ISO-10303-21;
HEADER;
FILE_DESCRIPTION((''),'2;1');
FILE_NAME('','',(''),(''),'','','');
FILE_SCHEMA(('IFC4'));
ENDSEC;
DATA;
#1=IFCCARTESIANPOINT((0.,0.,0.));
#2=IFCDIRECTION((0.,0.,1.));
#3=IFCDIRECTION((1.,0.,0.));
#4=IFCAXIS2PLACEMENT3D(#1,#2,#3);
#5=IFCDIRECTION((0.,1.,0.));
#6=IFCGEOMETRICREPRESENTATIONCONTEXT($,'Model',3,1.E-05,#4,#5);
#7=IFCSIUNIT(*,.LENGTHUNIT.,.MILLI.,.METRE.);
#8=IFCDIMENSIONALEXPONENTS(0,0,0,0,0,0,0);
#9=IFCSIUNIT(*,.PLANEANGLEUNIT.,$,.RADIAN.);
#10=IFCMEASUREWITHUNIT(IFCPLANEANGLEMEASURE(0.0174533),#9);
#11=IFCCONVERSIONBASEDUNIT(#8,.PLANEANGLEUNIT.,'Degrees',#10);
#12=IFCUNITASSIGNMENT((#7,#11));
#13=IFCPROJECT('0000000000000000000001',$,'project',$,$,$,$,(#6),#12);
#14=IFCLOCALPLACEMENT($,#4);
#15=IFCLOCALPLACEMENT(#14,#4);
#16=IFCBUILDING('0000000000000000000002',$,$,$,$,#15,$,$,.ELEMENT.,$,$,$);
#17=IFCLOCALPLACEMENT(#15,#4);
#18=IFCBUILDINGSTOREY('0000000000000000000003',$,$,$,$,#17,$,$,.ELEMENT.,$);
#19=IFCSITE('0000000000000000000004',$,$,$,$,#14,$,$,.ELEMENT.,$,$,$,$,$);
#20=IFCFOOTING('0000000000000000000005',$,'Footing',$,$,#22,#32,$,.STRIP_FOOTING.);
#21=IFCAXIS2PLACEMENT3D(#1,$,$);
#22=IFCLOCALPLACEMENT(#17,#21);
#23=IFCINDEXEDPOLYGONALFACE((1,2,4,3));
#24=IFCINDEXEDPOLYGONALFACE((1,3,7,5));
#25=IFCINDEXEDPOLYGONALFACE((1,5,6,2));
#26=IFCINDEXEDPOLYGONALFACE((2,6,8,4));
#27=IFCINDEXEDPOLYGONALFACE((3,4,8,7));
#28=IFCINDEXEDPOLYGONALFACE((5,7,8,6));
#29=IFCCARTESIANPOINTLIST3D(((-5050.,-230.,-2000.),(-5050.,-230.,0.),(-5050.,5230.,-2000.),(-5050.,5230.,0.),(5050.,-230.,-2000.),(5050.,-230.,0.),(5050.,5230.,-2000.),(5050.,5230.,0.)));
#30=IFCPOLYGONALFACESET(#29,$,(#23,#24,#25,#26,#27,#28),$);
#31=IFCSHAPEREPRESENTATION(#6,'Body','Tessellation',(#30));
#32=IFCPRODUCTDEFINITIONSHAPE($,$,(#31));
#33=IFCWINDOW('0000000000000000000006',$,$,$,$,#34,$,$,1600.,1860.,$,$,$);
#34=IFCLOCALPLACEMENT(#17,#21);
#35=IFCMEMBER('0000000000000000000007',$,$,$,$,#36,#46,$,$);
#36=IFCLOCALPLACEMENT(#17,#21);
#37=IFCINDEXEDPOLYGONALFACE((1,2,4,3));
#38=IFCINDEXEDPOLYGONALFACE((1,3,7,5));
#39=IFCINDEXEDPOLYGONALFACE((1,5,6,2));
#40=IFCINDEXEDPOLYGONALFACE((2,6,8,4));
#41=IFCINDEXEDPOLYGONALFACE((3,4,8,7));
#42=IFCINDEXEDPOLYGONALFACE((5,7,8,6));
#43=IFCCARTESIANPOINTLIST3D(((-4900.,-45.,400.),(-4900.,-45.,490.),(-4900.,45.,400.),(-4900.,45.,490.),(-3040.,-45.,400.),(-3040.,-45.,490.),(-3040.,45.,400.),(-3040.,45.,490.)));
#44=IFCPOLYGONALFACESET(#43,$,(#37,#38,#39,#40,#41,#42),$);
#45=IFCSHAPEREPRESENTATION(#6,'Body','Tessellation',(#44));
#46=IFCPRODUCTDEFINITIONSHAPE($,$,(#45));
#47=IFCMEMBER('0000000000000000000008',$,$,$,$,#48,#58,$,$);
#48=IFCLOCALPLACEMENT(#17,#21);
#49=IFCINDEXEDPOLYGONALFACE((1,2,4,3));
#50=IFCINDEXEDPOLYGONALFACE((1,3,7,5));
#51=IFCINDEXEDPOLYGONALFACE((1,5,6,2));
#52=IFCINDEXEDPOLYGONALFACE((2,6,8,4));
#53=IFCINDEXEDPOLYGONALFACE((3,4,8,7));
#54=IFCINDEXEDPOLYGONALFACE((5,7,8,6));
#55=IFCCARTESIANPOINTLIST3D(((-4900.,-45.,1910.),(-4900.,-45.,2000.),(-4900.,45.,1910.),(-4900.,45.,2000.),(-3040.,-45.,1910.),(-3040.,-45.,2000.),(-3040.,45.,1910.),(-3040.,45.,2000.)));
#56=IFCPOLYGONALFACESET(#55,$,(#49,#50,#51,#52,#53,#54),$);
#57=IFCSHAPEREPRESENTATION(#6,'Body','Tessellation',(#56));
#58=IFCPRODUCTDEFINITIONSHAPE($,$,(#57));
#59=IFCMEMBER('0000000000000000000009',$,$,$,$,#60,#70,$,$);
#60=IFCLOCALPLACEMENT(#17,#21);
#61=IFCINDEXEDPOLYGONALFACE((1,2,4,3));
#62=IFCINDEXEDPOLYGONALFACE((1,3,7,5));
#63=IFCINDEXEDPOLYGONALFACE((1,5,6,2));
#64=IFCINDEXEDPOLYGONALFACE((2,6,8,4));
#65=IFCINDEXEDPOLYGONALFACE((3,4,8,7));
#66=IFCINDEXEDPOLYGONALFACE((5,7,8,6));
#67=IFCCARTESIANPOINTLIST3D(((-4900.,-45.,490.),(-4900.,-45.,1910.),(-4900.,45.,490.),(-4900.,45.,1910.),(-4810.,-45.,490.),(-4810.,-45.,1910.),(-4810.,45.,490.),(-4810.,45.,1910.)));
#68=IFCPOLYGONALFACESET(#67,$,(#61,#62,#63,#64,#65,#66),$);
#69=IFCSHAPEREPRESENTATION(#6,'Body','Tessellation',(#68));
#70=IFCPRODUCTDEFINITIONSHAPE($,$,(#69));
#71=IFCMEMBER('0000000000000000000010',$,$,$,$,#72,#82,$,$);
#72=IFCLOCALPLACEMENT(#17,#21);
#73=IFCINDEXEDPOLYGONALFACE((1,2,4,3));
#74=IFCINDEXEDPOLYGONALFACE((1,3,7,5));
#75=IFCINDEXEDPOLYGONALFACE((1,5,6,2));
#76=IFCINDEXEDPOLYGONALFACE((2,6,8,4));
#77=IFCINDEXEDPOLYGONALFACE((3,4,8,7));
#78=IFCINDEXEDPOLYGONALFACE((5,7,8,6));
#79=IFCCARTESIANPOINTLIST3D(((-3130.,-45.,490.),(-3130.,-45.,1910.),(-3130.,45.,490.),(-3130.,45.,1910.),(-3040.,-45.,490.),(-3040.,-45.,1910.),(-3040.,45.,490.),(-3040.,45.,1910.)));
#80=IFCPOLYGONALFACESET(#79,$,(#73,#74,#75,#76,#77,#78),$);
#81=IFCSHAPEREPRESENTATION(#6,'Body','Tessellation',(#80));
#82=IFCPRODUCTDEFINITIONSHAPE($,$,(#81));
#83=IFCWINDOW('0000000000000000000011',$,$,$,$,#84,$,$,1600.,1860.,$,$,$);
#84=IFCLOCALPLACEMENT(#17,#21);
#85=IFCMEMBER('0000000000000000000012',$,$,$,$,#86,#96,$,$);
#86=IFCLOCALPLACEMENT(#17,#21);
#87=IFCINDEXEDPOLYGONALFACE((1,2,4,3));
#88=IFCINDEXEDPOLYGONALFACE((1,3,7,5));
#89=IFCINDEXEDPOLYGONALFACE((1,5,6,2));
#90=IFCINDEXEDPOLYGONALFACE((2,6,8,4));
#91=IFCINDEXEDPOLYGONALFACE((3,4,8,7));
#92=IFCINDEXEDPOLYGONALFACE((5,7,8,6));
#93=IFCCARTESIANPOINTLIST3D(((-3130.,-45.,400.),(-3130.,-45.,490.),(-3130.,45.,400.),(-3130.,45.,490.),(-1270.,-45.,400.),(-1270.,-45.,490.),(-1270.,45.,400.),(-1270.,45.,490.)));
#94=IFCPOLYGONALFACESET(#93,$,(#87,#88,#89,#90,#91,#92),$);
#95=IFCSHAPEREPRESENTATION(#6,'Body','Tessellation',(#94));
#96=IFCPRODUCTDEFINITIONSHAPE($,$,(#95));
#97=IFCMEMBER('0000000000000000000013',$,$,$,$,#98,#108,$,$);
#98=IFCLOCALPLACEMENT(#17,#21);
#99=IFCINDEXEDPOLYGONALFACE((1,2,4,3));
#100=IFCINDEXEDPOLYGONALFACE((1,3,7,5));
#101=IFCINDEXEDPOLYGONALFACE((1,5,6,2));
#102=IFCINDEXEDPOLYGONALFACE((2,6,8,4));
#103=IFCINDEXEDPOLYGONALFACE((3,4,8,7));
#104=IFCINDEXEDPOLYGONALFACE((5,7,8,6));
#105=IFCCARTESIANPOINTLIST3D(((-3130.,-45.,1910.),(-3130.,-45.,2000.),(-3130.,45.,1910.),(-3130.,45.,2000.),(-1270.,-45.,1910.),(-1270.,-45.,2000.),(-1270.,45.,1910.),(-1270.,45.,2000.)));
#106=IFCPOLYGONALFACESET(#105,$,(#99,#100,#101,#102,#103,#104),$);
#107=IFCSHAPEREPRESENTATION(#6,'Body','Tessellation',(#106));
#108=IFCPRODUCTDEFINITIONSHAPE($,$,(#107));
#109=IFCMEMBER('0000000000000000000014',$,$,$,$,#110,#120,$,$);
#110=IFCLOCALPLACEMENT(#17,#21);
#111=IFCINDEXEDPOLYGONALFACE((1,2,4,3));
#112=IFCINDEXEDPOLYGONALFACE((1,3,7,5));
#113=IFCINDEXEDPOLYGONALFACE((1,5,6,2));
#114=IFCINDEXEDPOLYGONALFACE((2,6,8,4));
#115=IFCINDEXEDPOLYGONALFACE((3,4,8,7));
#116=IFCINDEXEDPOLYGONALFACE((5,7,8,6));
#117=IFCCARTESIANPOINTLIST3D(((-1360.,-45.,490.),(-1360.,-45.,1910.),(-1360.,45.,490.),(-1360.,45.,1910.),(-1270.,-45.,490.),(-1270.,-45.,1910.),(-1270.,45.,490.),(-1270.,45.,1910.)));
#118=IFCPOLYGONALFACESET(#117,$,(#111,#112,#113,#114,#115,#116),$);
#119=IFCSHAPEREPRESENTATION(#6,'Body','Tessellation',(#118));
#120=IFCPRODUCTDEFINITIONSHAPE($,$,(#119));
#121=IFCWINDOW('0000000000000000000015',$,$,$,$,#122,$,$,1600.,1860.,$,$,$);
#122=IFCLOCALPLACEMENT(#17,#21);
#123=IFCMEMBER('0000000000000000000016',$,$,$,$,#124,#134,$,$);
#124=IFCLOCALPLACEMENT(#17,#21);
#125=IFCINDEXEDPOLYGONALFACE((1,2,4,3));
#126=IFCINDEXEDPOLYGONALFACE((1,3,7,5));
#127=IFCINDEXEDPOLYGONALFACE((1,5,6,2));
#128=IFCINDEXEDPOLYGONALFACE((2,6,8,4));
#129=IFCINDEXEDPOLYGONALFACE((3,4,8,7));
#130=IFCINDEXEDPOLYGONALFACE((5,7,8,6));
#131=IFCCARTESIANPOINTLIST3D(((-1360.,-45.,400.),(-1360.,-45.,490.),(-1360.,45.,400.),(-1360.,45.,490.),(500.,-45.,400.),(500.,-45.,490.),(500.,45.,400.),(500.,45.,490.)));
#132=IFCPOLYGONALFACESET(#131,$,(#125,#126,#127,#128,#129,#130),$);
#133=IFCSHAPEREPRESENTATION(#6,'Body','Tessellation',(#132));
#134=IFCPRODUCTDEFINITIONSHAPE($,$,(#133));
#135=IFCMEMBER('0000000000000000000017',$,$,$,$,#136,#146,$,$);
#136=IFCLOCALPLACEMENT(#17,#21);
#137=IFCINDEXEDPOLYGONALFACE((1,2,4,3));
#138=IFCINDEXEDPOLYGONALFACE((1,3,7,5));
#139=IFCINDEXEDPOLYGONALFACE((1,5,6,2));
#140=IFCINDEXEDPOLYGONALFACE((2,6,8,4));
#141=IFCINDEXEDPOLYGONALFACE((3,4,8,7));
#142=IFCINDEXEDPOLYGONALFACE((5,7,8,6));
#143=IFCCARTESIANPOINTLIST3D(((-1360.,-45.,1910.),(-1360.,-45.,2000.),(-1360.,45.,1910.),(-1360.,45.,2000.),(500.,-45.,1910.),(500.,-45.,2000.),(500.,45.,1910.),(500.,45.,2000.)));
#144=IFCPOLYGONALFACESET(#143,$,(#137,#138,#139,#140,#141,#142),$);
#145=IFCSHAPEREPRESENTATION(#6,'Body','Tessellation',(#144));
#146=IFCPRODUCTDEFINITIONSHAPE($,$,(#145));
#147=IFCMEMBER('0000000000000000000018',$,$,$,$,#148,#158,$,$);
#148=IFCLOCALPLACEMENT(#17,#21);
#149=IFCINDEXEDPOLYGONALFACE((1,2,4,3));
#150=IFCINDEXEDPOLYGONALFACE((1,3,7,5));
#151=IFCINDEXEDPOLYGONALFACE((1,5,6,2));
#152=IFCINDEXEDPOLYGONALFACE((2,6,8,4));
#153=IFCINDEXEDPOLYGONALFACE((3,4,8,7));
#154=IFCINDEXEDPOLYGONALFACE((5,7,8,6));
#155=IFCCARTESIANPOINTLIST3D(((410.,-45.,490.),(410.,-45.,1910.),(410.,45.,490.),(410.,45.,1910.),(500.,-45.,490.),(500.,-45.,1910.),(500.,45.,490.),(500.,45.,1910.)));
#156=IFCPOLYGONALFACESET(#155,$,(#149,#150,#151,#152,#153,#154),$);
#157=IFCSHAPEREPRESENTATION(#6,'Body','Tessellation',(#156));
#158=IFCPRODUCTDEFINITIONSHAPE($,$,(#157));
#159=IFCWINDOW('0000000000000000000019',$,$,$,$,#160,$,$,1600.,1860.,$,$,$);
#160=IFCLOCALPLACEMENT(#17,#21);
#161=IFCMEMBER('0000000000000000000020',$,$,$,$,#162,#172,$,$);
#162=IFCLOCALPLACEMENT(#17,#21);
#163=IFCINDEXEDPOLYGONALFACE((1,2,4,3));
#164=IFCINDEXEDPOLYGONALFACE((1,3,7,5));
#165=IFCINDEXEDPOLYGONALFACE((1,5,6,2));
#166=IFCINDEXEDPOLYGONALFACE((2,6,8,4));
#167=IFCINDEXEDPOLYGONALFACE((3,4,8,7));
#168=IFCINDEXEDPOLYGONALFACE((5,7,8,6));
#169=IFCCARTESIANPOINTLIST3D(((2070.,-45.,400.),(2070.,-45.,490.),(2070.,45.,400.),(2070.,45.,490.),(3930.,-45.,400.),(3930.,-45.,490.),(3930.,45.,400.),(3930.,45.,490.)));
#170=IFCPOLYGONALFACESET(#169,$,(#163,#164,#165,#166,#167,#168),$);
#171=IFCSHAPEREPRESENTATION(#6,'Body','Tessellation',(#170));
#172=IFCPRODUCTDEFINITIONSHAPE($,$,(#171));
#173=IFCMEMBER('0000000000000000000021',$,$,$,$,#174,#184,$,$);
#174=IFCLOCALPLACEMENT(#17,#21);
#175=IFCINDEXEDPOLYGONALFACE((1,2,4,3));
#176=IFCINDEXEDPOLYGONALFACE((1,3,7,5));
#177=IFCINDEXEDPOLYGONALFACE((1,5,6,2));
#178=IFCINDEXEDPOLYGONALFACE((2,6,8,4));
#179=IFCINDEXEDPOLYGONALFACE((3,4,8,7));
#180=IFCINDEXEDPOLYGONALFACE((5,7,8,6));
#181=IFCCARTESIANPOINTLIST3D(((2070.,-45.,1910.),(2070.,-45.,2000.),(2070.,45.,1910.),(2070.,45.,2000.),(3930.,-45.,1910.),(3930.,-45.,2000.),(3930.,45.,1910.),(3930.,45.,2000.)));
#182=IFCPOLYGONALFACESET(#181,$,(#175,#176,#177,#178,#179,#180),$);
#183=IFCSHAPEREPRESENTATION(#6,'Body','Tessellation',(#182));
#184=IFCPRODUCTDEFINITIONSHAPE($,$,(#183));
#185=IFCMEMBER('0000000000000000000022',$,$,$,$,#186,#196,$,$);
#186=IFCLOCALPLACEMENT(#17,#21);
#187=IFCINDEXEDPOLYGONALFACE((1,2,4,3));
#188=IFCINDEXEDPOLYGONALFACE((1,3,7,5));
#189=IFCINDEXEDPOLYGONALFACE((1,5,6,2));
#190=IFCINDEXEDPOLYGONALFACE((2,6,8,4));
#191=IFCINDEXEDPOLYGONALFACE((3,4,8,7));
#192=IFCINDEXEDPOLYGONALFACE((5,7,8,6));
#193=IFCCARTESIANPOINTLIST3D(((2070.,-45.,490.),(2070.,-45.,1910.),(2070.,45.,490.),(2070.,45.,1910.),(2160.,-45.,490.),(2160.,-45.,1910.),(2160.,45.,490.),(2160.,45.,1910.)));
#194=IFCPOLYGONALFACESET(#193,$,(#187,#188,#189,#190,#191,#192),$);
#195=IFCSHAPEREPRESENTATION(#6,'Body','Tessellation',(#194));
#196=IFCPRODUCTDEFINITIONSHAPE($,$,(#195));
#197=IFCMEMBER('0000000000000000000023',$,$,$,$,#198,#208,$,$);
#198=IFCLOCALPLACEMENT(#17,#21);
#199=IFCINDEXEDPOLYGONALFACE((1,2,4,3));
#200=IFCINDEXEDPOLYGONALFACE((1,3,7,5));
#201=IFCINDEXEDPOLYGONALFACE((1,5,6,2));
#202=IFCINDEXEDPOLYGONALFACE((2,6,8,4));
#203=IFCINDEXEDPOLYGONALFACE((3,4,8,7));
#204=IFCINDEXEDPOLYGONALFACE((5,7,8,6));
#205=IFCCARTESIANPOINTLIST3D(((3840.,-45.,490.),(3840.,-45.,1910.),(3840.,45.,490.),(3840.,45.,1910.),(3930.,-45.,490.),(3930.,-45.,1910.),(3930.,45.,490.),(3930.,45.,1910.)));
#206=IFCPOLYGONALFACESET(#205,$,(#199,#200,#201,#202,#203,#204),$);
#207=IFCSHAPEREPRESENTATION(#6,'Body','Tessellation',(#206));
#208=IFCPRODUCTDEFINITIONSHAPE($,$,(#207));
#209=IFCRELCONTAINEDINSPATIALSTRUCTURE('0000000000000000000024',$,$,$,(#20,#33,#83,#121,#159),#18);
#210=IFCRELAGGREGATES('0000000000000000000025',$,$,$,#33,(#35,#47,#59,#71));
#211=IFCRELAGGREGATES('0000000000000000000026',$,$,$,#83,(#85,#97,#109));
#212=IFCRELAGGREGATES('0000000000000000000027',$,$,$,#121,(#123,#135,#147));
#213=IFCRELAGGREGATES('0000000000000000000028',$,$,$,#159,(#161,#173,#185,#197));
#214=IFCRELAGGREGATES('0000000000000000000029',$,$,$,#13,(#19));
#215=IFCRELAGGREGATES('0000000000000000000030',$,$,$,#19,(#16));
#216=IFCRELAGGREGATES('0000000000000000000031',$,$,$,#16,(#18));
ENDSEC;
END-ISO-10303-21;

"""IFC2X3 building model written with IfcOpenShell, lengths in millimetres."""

from ifc_helpers import new_model, entity, si_unit, converted_unit, direction, frame, origin_with_axes, place, context, project, spatial, polyline, outline, extrude, element, aggregate, save


model = new_model("IFC2X3")

# Units and contexts
model_context = context("Model", 3, precision=1e-05, world=origin_with_axes(), true_north=direction((0.0, 1.0, 0.0)))
ifc_project = project(units=[si_unit("LENGTHUNIT", "METRE", prefix="MILLI"), converted_unit("PLANEANGLEUNIT", "Degrees", entity("IfcPlaneAngleMeasure", 0.0174533), si_unit("PLANEANGLEUNIT", "RADIAN"), dimensions=[0, 0, 0, 0, 0, 0, 0])], contexts=[model_context])

# Site, building, storey
placement = place(None, origin_with_axes())
site = spatial("IfcSite", under=ifc_project, at=placement, CompositionType="ELEMENT")
building_placement = place(placement, origin_with_axes())
building = spatial("IfcBuilding", under=site, at=building_placement, CompositionType="ELEMENT")
storey_placement = place(building_placement, origin_with_axes())
storey = spatial("IfcBuildingStorey", under=building, at=storey_placement, CompositionType="ELEMENT")

# Footing
footing_placement = place(None, frame((0.0, 2500.0, -2000.0), z_axis=(0.0, 0.0, 1.0), x_axis=(1.0, 0.0, 0.0)))
element("IfcFooting", 1, at=footing_placement, inside=storey, Name="Footing", PredefinedType="STRIP_FOOTING", context=model_context, shape_type="SweptSolid", body=[
    extrude(outline(polyline([(-5050.0, -2730.0), (5050.0, -2730.0), (5050.0, 2730.0), (-5050.0, 2730.0), (-5050.0, -2730.0), (-5050.0, -2730.0)])), origin_with_axes(), (0.0, 0.0, 1.0), 2000.0),
])

# Windows, members
window_1_placement = place(storey_placement, frame((-4900.0, -45.0, 400.0), z_axis=(0.0, 0.0, 1.0), x_axis=(1.0, 0.0, 0.0)))
window_1 = element("IfcWindow", 2, at=window_1_placement, inside=storey, OverallHeight=1600.0, OverallWidth=1860.0)
member_1_placement = place(window_1_placement, frame((930.0, 45.0, 0.0), z_axis=(0.0, 0.0, 1.0), x_axis=(1.0, 0.0, 0.0)))
member_1 = element("IfcMember", 3, at=member_1_placement, context=model_context, shape_type="SweptSolid", body=[
    extrude(outline(polyline([(-930.0, -45.0), (930.0, -45.0), (930.0, 45.0), (-930.0, 45.0), (-930.0, -45.0), (-930.0, -45.0)])), origin_with_axes(), (0.0, 0.0, 1.0), 90.0),
])
member_2_placement = place(window_1_placement, frame((930.0, 45.0, 1510.0), z_axis=(0.0, 0.0, 1.0), x_axis=(1.0, 0.0, 0.0)))
member_2 = element("IfcMember", 4, at=member_2_placement, context=model_context, shape_type="SweptSolid", body=[
    extrude(outline(polyline([(-930.0, -45.0), (930.0, -45.0), (930.0, 45.0), (-930.0, 45.0), (-930.0, -45.0), (-930.0, -45.0)])), origin_with_axes(), (0.0, 0.0, 1.0), 90.0),
])
member_3_placement = place(window_1_placement, frame((45.0, 45.0, 90.0), z_axis=(0.0, 0.0, 1.0), x_axis=(1.0, 0.0, 0.0)))
member_3 = element("IfcMember", 5, at=member_3_placement, context=model_context, shape_type="SweptSolid", body=[
    extrude(outline(polyline([(-45.0, -45.0), (45.0, -45.0), (45.0, 45.0), (-45.0, 45.0), (-45.0, -45.0), (-45.0, -45.0)])), origin_with_axes(), (0.0, 0.0, 1.0), 1420.0),
])
member_4_placement = place(window_1_placement, frame((1815.0, 45.0, 90.0), z_axis=(0.0, 0.0, 1.0), x_axis=(1.0, 0.0, 0.0)))
member_4 = element("IfcMember", 6, at=member_4_placement, context=model_context, shape_type="SweptSolid", body=[
    extrude(outline(polyline([(-45.0, -45.0), (45.0, -45.0), (45.0, 45.0), (-45.0, 45.0), (-45.0, -45.0), (-45.0, -45.0)])), origin_with_axes(), (0.0, 0.0, 1.0), 1420.0),
])
window_2_placement = place(storey_placement, frame((-3130.0, -45.0, 400.0), z_axis=(0.0, 0.0, 1.0), x_axis=(1.0, 0.0, 0.0)))
window_2 = element("IfcWindow", 7, at=window_2_placement, inside=storey, OverallHeight=1600.0, OverallWidth=1860.0)
member_5_placement = place(window_2_placement, frame((930.0, 45.0, 0.0), z_axis=(0.0, 0.0, 1.0), x_axis=(1.0, 0.0, 0.0)))
member_5 = element("IfcMember", 8, at=member_5_placement, context=model_context, shape_type="SweptSolid", body=[
    extrude(outline(polyline([(-930.0, -45.0), (930.0, -45.0), (930.0, 45.0), (-930.0, 45.0), (-930.0, -45.0), (-930.0, -45.0)])), origin_with_axes(), (0.0, 0.0, 1.0), 90.0),
])
member_6_placement = place(window_2_placement, frame((930.0, 45.0, 1510.0), z_axis=(0.0, 0.0, 1.0), x_axis=(1.0, 0.0, 0.0)))
member_6 = element("IfcMember", 9, at=member_6_placement, context=model_context, shape_type="SweptSolid", body=[
    extrude(outline(polyline([(-930.0, -45.0), (930.0, -45.0), (930.0, 45.0), (-930.0, 45.0), (-930.0, -45.0), (-930.0, -45.0)])), origin_with_axes(), (0.0, 0.0, 1.0), 90.0),
])
member_7_placement = place(window_2_placement, frame((1815.0, 45.0, 90.0), z_axis=(0.0, 0.0, 1.0), x_axis=(1.0, 0.0, 0.0)))
member_7 = element("IfcMember", 10, at=member_7_placement, context=model_context, shape_type="SweptSolid", body=[
    extrude(outline(polyline([(-45.0, -45.0), (45.0, -45.0), (45.0, 45.0), (-45.0, 45.0), (-45.0, -45.0), (-45.0, -45.0)])), origin_with_axes(), (0.0, 0.0, 1.0), 1420.0),
])
window_3_placement = place(storey_placement, frame((-1360.0, -45.0, 400.0), z_axis=(0.0, 0.0, 1.0), x_axis=(1.0, 0.0, 0.0)))
window_3 = element("IfcWindow", 11, at=window_3_placement, inside=storey, OverallHeight=1600.0, OverallWidth=1860.0)
member_8_placement = place(window_3_placement, frame((930.0, 45.0, 0.0), z_axis=(0.0, 0.0, 1.0), x_axis=(1.0, 0.0, 0.0)))
member_8 = element("IfcMember", 12, at=member_8_placement, context=model_context, shape_type="SweptSolid", body=[
    extrude(outline(polyline([(-930.0, -45.0), (930.0, -45.0), (930.0, 45.0), (-930.0, 45.0), (-930.0, -45.0), (-930.0, -45.0)])), origin_with_axes(), (0.0, 0.0, 1.0), 90.0),
])
member_9_placement = place(window_3_placement, frame((930.0, 45.0, 1510.0), z_axis=(0.0, 0.0, 1.0), x_axis=(1.0, 0.0, 0.0)))
member_9 = element("IfcMember", 13, at=member_9_placement, context=model_context, shape_type="SweptSolid", body=[
    extrude(outline(polyline([(-930.0, -45.0), (930.0, -45.0), (930.0, 45.0), (-930.0, 45.0), (-930.0, -45.0), (-930.0, -45.0)])), origin_with_axes(), (0.0, 0.0, 1.0), 90.0),
])
member_10_placement = place(window_3_placement, frame((1815.0, 45.0, 90.0), z_axis=(0.0, 0.0, 1.0), x_axis=(1.0, 0.0, 0.0)))
member_10 = element("IfcMember", 14, at=member_10_placement, context=model_context, shape_type="SweptSolid", body=[
    extrude(outline(polyline([(-45.0, -45.0), (45.0, -45.0), (45.0, 45.0), (-45.0, 45.0), (-45.0, -45.0), (-45.0, -45.0)])), origin_with_axes(), (0.0, 0.0, 1.0), 1420.0),
])
window_4_placement = place(storey_placement, frame((2070.0, -45.0, 400.0), z_axis=(0.0, 0.0, 1.0), x_axis=(1.0, 0.0, 0.0)))
window_4 = element("IfcWindow", 15, at=window_4_placement, inside=storey, OverallHeight=1600.0, OverallWidth=1860.0)
member_11_placement = place(window_4_placement, frame((930.0, 45.0, 0.0), z_axis=(0.0, 0.0, 1.0), x_axis=(1.0, 0.0, 0.0)))
member_11 = element("IfcMember", 16, at=member_11_placement, context=model_context, shape_type="SweptSolid", body=[
    extrude(outline(polyline([(-930.0, -45.0), (930.0, -45.0), (930.0, 45.0), (-930.0, 45.0), (-930.0, -45.0), (-930.0, -45.0)])), origin_with_axes(), (0.0, 0.0, 1.0), 90.0),
])
member_12_placement = place(window_4_placement, frame((930.0, 45.0, 1510.0), z_axis=(0.0, 0.0, 1.0), x_axis=(1.0, 0.0, 0.0)))
member_12 = element("IfcMember", 17, at=member_12_placement, context=model_context, shape_type="SweptSolid", body=[
    extrude(outline(polyline([(-930.0, -45.0), (930.0, -45.0), (930.0, 45.0), (-930.0, 45.0), (-930.0, -45.0), (-930.0, -45.0)])), origin_with_axes(), (0.0, 0.0, 1.0), 90.0),
])
member_13_placement = place(window_4_placement, frame((45.0, 45.0, 90.0), z_axis=(0.0, 0.0, 1.0), x_axis=(1.0, 0.0, 0.0)))
member_13 = element("IfcMember", 18, at=member_13_placement, context=model_context, shape_type="SweptSolid", body=[
    extrude(outline(polyline([(-45.0, -45.0), (45.0, -45.0), (45.0, 45.0), (-45.0, 45.0), (-45.0, -45.0), (-45.0, -45.0)])), origin_with_axes(), (0.0, 0.0, 1.0), 1420.0),
])
member_14_placement = place(window_4_placement, frame((1815.0, 45.0, 90.0), z_axis=(0.0, 0.0, 1.0), x_axis=(1.0, 0.0, 0.0)))
member_14 = element("IfcMember", 19, at=member_14_placement, context=model_context, shape_type="SweptSolid", body=[
    extrude(outline(polyline([(-45.0, -45.0), (45.0, -45.0), (45.0, 45.0), (-45.0, 45.0), (-45.0, -45.0), (-45.0, -45.0)])), origin_with_axes(), (0.0, 0.0, 1.0), 1420.0),
])

aggregate(window_1, [member_1, member_2, member_3, member_4])
aggregate(window_2, [member_5, member_6, member_7])
aggregate(window_3, [member_8, member_9, member_10])
aggregate(window_4, [member_11, member_12, member_13, member_14])

save(model, "model.ifc")
